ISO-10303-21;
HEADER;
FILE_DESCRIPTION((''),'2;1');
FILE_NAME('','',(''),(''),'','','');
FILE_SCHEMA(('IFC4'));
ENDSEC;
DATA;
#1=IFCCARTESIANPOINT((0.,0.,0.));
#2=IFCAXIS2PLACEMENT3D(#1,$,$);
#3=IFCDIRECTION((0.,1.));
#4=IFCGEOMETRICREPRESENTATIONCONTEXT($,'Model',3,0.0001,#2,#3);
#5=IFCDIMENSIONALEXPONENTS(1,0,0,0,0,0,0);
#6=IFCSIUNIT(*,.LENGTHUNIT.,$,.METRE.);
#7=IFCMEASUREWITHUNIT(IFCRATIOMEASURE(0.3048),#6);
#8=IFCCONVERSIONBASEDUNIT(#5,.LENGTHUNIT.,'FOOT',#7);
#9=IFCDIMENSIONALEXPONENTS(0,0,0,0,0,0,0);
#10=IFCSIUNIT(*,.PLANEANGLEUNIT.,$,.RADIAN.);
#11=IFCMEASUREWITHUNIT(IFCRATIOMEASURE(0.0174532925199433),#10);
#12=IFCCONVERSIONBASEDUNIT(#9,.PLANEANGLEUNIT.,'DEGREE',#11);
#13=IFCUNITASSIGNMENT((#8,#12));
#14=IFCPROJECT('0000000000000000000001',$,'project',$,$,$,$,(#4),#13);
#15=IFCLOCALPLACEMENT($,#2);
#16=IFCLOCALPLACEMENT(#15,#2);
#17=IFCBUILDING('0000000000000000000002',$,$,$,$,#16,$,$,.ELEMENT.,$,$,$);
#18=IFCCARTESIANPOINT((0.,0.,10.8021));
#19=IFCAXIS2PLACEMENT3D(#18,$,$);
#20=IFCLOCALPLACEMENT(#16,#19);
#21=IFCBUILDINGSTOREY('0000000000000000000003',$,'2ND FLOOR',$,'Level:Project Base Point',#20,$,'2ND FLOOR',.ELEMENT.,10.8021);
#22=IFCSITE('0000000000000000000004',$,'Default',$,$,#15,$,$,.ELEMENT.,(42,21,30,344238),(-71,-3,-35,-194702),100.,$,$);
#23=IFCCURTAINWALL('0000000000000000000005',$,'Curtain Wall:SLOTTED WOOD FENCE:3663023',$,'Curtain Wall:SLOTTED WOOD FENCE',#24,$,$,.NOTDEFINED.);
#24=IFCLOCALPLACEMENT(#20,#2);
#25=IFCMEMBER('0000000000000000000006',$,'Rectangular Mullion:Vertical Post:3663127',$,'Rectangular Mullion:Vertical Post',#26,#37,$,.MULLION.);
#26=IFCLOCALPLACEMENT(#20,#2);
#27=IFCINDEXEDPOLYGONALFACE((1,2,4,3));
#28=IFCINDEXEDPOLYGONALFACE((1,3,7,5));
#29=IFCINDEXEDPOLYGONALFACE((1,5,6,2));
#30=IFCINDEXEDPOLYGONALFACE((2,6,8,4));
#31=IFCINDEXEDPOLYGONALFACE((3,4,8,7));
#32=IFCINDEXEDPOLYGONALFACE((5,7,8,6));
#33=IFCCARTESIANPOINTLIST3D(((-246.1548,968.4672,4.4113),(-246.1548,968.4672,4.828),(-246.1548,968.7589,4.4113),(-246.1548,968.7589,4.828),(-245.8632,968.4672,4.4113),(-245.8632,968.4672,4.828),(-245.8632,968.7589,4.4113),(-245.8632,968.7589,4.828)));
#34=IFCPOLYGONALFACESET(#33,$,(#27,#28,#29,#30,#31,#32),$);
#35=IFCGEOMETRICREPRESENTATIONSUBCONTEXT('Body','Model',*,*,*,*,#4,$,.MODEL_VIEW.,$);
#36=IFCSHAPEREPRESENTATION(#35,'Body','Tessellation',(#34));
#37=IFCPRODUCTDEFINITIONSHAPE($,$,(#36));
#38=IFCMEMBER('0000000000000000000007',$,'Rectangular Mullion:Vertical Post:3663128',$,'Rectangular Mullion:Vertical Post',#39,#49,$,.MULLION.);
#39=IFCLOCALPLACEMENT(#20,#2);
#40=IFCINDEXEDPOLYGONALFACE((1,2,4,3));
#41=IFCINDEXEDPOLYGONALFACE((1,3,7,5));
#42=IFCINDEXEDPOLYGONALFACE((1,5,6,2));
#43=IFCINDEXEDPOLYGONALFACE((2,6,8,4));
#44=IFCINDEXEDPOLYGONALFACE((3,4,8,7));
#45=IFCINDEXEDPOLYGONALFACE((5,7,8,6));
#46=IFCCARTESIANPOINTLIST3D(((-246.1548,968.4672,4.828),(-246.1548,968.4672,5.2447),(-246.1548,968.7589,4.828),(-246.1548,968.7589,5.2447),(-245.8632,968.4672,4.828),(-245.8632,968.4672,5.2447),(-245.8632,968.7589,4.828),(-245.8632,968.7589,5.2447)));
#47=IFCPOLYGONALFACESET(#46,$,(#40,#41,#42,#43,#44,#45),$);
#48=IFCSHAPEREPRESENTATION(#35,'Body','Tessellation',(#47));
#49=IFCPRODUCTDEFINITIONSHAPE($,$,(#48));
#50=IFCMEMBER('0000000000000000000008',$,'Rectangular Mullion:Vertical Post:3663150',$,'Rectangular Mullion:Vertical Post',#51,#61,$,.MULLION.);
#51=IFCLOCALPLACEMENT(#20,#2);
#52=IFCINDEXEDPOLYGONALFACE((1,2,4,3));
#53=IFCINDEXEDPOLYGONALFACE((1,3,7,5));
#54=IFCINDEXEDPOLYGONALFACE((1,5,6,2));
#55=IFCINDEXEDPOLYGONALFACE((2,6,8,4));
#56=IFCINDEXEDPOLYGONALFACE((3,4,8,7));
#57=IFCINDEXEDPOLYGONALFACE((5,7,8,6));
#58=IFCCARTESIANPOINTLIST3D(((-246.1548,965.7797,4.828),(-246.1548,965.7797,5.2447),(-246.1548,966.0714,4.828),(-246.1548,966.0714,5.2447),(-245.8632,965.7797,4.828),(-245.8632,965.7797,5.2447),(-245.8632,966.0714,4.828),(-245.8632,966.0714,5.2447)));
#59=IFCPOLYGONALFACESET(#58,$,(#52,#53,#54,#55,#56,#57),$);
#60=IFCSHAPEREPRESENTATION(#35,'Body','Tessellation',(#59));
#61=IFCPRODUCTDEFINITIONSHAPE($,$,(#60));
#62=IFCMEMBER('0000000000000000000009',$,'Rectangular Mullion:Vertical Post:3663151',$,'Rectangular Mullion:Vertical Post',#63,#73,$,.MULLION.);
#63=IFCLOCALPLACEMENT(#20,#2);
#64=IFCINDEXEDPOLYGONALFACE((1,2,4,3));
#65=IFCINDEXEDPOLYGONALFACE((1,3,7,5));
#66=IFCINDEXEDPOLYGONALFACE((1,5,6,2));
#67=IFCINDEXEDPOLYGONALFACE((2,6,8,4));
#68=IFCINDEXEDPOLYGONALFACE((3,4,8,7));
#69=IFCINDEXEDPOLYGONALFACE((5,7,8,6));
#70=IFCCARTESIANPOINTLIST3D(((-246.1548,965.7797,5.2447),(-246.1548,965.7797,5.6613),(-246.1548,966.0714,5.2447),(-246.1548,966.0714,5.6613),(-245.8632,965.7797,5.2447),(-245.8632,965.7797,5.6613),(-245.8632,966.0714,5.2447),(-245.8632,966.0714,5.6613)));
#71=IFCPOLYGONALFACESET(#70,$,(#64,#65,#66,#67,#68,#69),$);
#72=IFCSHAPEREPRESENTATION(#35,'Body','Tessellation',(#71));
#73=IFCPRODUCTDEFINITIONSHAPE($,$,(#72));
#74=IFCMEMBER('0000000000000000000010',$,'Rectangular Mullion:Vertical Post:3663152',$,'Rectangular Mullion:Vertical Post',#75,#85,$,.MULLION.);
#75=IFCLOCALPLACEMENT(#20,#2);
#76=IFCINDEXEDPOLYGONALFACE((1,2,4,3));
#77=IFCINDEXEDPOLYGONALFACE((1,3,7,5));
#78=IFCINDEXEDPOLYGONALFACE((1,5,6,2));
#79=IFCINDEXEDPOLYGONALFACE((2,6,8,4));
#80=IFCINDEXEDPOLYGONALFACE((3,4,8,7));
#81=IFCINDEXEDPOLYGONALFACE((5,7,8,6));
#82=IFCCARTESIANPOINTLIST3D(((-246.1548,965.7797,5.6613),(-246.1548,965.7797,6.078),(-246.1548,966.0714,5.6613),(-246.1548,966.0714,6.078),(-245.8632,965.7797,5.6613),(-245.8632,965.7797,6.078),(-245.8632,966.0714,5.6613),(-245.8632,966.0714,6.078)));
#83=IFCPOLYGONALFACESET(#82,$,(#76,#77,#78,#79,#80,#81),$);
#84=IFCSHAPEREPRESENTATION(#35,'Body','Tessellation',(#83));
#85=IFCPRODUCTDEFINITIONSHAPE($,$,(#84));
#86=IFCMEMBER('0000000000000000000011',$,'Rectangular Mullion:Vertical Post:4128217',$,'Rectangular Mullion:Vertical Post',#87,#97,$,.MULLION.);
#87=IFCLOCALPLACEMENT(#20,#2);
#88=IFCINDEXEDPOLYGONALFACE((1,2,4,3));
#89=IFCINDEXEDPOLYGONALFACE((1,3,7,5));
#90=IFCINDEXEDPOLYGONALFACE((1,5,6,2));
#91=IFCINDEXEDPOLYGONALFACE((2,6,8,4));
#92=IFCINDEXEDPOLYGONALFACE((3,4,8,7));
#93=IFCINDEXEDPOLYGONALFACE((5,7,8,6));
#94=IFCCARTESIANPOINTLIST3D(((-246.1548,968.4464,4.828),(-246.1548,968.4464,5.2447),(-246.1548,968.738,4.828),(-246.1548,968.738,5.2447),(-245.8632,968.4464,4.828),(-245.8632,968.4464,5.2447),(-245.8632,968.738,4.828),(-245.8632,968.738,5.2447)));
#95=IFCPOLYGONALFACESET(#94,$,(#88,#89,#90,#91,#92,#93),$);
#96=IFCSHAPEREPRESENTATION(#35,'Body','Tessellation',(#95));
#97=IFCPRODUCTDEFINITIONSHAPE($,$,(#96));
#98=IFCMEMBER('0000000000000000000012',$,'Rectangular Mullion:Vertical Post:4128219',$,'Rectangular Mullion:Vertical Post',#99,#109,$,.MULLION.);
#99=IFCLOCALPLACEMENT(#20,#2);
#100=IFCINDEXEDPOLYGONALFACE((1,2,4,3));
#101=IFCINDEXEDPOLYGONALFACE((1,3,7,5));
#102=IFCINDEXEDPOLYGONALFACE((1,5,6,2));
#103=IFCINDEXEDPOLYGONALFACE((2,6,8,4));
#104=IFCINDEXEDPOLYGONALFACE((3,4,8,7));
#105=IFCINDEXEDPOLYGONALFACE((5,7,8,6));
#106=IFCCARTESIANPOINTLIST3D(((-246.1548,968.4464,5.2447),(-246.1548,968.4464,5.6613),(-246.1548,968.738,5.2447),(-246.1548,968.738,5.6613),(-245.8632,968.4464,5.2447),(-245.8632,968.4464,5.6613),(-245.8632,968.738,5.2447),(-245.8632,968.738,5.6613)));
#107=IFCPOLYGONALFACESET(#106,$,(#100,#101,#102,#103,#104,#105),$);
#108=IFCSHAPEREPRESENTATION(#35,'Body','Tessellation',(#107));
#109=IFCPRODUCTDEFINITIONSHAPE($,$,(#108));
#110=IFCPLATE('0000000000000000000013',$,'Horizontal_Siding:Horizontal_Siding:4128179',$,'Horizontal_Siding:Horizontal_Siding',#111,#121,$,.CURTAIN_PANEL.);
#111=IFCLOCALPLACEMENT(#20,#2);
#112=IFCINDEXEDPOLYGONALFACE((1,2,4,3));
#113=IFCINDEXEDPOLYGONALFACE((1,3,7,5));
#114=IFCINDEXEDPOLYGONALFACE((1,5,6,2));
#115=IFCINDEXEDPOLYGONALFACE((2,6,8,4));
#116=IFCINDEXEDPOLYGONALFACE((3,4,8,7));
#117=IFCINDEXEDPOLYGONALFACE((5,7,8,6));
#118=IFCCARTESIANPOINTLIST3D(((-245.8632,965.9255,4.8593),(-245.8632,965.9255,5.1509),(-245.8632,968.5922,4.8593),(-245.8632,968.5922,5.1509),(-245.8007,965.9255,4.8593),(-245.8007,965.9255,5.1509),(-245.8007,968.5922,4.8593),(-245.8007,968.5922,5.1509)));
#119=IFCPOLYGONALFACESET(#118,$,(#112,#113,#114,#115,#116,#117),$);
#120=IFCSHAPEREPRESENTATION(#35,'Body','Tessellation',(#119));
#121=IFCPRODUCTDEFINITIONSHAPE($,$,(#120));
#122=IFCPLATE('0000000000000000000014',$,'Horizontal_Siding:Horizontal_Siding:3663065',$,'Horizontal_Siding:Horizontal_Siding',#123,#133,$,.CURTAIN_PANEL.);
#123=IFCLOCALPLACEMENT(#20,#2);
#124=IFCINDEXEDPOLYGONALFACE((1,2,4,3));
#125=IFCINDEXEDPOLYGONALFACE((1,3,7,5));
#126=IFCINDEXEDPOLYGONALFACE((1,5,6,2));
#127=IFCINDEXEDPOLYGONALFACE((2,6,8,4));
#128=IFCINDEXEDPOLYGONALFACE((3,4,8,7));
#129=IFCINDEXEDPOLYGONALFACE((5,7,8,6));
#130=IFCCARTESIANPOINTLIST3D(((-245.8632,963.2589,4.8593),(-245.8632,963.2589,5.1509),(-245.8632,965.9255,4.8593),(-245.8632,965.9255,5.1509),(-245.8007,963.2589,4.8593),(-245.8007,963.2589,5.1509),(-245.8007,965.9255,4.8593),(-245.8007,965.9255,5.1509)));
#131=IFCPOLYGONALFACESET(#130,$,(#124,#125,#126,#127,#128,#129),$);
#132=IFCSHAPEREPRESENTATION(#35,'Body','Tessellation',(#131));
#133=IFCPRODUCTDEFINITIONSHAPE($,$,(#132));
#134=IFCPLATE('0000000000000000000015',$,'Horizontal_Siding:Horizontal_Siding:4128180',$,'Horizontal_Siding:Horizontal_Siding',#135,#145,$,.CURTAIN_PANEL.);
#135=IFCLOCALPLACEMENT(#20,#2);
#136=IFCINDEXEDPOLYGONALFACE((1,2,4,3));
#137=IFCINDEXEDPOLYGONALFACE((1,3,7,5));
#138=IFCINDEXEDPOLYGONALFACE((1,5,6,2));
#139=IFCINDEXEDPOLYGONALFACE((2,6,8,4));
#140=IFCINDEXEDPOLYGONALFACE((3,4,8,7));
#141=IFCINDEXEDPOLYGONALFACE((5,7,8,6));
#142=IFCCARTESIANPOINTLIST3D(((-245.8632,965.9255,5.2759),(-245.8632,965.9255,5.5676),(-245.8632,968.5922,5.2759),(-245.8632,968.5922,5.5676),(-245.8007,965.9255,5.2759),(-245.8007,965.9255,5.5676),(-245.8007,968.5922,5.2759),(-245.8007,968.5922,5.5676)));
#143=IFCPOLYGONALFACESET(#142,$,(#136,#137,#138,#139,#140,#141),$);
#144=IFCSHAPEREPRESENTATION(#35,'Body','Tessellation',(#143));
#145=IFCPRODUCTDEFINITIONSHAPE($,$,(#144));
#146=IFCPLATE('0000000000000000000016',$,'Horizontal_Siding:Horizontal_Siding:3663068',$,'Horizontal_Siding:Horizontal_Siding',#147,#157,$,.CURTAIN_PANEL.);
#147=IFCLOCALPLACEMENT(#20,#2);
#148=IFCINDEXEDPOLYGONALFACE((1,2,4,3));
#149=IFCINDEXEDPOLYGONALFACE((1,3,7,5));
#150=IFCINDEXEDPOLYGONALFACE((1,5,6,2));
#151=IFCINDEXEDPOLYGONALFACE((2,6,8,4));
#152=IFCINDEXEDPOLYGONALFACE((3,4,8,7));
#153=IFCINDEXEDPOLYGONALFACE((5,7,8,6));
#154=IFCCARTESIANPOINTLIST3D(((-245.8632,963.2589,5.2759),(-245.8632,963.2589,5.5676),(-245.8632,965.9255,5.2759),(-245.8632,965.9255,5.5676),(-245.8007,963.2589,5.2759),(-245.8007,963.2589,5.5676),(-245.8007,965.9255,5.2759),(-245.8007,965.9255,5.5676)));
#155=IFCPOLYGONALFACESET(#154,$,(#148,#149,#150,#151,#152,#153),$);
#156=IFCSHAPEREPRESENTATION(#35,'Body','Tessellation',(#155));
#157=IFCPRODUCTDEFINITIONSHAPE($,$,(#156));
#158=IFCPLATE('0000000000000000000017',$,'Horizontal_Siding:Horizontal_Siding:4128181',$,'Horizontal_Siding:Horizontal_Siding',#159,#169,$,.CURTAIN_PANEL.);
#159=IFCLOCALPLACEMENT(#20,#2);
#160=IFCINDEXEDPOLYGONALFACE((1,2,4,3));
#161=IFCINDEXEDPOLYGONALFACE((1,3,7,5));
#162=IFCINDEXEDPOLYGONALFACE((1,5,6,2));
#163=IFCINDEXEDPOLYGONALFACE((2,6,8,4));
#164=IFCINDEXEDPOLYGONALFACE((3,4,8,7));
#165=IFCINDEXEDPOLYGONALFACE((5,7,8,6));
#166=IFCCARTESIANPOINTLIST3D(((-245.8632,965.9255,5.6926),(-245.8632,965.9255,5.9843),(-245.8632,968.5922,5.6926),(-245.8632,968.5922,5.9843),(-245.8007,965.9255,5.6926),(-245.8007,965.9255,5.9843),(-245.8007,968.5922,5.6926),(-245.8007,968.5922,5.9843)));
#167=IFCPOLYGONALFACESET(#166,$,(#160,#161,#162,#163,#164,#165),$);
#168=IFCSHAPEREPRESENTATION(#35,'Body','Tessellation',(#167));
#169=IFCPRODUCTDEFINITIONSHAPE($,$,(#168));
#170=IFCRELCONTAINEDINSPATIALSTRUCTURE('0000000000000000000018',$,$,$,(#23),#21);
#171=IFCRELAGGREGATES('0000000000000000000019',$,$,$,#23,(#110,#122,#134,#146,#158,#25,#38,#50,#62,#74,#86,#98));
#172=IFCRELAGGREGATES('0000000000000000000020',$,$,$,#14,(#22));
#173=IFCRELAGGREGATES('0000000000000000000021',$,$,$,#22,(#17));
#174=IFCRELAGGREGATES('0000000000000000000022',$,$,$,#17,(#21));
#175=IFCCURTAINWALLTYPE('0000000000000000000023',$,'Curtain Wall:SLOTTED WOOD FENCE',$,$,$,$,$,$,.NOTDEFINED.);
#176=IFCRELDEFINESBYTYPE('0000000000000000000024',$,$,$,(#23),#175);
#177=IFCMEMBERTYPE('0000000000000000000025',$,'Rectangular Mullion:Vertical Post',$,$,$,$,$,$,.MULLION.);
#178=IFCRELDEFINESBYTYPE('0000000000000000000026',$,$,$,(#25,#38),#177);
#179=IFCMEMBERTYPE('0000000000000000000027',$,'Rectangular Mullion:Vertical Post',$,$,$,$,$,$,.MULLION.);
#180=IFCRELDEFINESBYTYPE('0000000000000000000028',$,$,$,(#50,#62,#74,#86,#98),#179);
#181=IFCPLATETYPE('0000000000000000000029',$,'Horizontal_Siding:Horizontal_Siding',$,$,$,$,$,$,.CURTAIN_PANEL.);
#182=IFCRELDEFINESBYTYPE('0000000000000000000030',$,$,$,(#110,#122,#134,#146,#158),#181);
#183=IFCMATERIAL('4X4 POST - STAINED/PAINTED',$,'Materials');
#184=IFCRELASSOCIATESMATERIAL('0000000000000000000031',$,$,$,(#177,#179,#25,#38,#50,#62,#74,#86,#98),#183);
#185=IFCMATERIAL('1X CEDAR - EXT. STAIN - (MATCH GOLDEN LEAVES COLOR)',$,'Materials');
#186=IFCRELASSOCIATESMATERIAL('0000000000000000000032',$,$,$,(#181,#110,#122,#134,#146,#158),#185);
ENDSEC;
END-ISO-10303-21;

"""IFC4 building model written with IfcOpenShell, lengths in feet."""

from ifc_helpers import new_model, entity, si_unit, converted_unit, direction, frame, origin, origin_2d_with_axis, place, context, subcontext, project, spatial, rectangle, extrude, source, transform, mapped, material, material_profile, profile_set, profile_usage, type_object, type_shapes, element, aggregate, save


model = new_model("IFC4")

# Units and contexts
model_context = context("Model", 3, precision=0.0001, world=origin(), true_north=direction((0.0, 1.0)))
body_context = subcontext(model_context, "Body", "Model", "MODEL_VIEW")
ifc_project = project(units=[converted_unit("LENGTHUNIT", "FOOT", entity("IfcRatioMeasure", 0.3048), si_unit("LENGTHUNIT", "METRE"), dimensions=[1, 0, 0, 0, 0, 0, 0]), converted_unit("PLANEANGLEUNIT", "DEGREE", entity("IfcRatioMeasure", 0.0174532925199433), si_unit("PLANEANGLEUNIT", "RADIAN"), dimensions=[0, 0, 0, 0, 0, 0, 0])], contexts=[model_context])

# Site, building, storey
site_placement = place(None, origin())
site = spatial("IfcSite", under=ifc_project, at=site_placement, Name="Default", CompositionType="ELEMENT", RefLatitude=(42, 21, 30, 344238), RefLongitude=(-71, -3, -35, -194702), RefElevation=100.0)
building_placement = place(site_placement, origin())
building = spatial("IfcBuilding", under=site, at=building_placement, CompositionType="ELEMENT")
storey_placement = place(building_placement, frame((0.0, 0.0, 10.8021)))
storey = spatial("IfcBuildingStorey", under=building, at=storey_placement, Name="2ND FLOOR", ObjectType="Level:Project Base Point", LongName="2ND FLOOR", CompositionType="ELEMENT", Elevation=10.8021)

# Curtain wall, members, plates
curtain_wall_type = type_object("IfcCurtainWallType", Name="Curtain Wall:SLOTTED WOOD FENCE", PredefinedType="NOTDEFINED")
curtain_wall_placement = place(storey_placement, frame((0.0, 0.0, -10.8021)))
curtain_wall = element("IfcCurtainWall", 1, at=curtain_wall_placement, inside=storey, type_object=curtain_wall_type, Name="Curtain Wall:SLOTTED WOOD FENCE:3663023", ObjectType="Curtain Wall:SLOTTED WOOD FENCE", PredefinedType="NOTDEFINED")
ifc_material_1 = material(Name="4X4 POST - STAINED/PAINTED", Category="Materials")
ifc_material_profile = material_profile(ifc_material_1, rectangle(XDim=0.2917, YDim=0.2917, at=origin_2d_with_axis()), Name="Vertical Post")
ifc_profile_set = profile_set([ifc_material_profile], Name="Vertical Post")
ifc_profile_usage_1 = profile_usage(ifc_profile_set)
member_type_1 = type_object("IfcMemberType", Name="Rectangular Mullion:Vertical Post", PredefinedType="MULLION", material=ifc_profile_set)
shared_shape_1 = source(origin(), body_context, "Body", "SweptSolid", [
    extrude(rectangle(XDim=0.2917, YDim=0.2917, at=origin_2d_with_axis()), frame((-0.1458, 0.2083, -0.4167), z_axis=(0.0, 0.0, 1.0), x_axis=(0.0, -1.0, 0.0)), (0.0, 0.0, 1.0), 0.4167),
])
type_shapes(member_type_1, [shared_shape_1])
member_1_placement = place(storey_placement, frame((-245.8007, 968.7589, 4.828), z_axis=(0.0, 0.0, 1.0), x_axis=(0.0, 1.0, 0.0)))
member_1 = element("IfcMember", 2, at=member_1_placement, type_object=member_type_1, material=ifc_profile_usage_1, Name="Rectangular Mullion:Vertical Post:3663127", ObjectType="Rectangular Mullion:Vertical Post", PredefinedType="MULLION", context=body_context, shape_type="MappedRepresentation", body=[
    mapped(shared_shape_1, transform((0.0, 0.0, 0.0), scale=1.0)),
])
ifc_profile_usage_2 = profile_usage(ifc_profile_set)
member_2_placement = place(storey_placement, frame((-245.8007, 968.7589, 5.2447), z_axis=(0.0, 0.0, 1.0), x_axis=(0.0, 1.0, 0.0)))
member_2 = element("IfcMember", 3, at=member_2_placement, type_object=member_type_1, material=ifc_profile_usage_2, Name="Rectangular Mullion:Vertical Post:3663128", ObjectType="Rectangular Mullion:Vertical Post", PredefinedType="MULLION", context=body_context, shape_type="MappedRepresentation", body=[
    mapped(shared_shape_1, transform((0.0, 0.0, 0.0), scale=1.0)),
])
ifc_profile_usage_3 = profile_usage(ifc_profile_set)
member_type_2 = type_object("IfcMemberType", Name="Rectangular Mullion:Vertical Post", PredefinedType="MULLION", material=ifc_profile_set)
shared_shape_2 = source(origin(), body_context, "Body", "SweptSolid", [
    extrude(rectangle(XDim=0.2917, YDim=0.2917, at=origin_2d_with_axis()), frame((0.0, 0.2083, -0.4167), z_axis=(0.0, 0.0, 1.0), x_axis=(0.0, -1.0, 0.0)), (0.0, 0.0, 1.0), 0.4167),
])
type_shapes(member_type_2, [shared_shape_2])
member_3_placement = place(storey_placement, frame((-245.8007, 965.9255, 4.828), z_axis=(0.0, 0.0, -1.0), x_axis=(0.0, -1.0, 0.0)))
member_3 = element("IfcMember", 4, at=member_3_placement, type_object=member_type_2, material=ifc_profile_usage_3, Name="Rectangular Mullion:Vertical Post:3663150", ObjectType="Rectangular Mullion:Vertical Post", PredefinedType="MULLION", context=body_context, shape_type="MappedRepresentation", body=[
    mapped(shared_shape_2, transform((0.0, 0.0, 0.0), scale=1.0)),
])
ifc_profile_usage_4 = profile_usage(ifc_profile_set)
member_4_placement = place(storey_placement, frame((-245.8007, 965.9255, 5.2447), z_axis=(0.0, 0.0, -1.0), x_axis=(0.0, -1.0, 0.0)))
member_4 = element("IfcMember", 5, at=member_4_placement, type_object=member_type_2, material=ifc_profile_usage_4, Name="Rectangular Mullion:Vertical Post:3663151", ObjectType="Rectangular Mullion:Vertical Post", PredefinedType="MULLION", context=body_context, shape_type="MappedRepresentation", body=[
    mapped(shared_shape_2, transform((0.0, 0.0, 0.0), scale=1.0)),
])
ifc_profile_usage_5 = profile_usage(ifc_profile_set)
member_5_placement = place(storey_placement, frame((-245.8007, 965.9255, 5.6613), z_axis=(0.0, 0.0, -1.0), x_axis=(0.0, -1.0, 0.0)))
member_5 = element("IfcMember", 6, at=member_5_placement, type_object=member_type_2, material=ifc_profile_usage_5, Name="Rectangular Mullion:Vertical Post:3663152", ObjectType="Rectangular Mullion:Vertical Post", PredefinedType="MULLION", context=body_context, shape_type="MappedRepresentation", body=[
    mapped(shared_shape_2, transform((0.0, 0.0, 0.0), scale=1.0)),
])
ifc_profile_usage_6 = profile_usage(ifc_profile_set)
member_6_placement = place(storey_placement, frame((-245.8007, 968.5922, 4.828), z_axis=(0.0, 0.0, -1.0), x_axis=(0.0, -1.0, 0.0)))
member_6 = element("IfcMember", 7, at=member_6_placement, type_object=member_type_2, material=ifc_profile_usage_6, Name="Rectangular Mullion:Vertical Post:4128217", ObjectType="Rectangular Mullion:Vertical Post", PredefinedType="MULLION", context=body_context, shape_type="MappedRepresentation", body=[
    mapped(shared_shape_2, transform((0.0, 0.0, 0.0), scale=1.0)),
])
ifc_profile_usage_7 = profile_usage(ifc_profile_set)
member_7_placement = place(storey_placement, frame((-245.8007, 968.5922, 5.2447), z_axis=(0.0, 0.0, -1.0), x_axis=(0.0, -1.0, 0.0)))
member_7 = element("IfcMember", 8, at=member_7_placement, type_object=member_type_2, material=ifc_profile_usage_7, Name="Rectangular Mullion:Vertical Post:4128219", ObjectType="Rectangular Mullion:Vertical Post", PredefinedType="MULLION", context=body_context, shape_type="MappedRepresentation", body=[
    mapped(shared_shape_2, transform((0.0, 0.0, 0.0), scale=1.0)),
])
ifc_material_2 = material(Name="1X CEDAR - EXT. STAIN - (MATCH GOLDEN LEAVES COLOR)", Category="Materials")
plate_type_1 = type_object("IfcPlateType", Name="Horizontal_Siding:Horizontal_Siding", PredefinedType="CURTAIN_PANEL", material=ifc_material_2)
shared_shape_3 = source(origin(), body_context, "Body", "SweptSolid", [
    extrude(rectangle(XDim=0.0625, YDim=2.6667, at=origin_2d_with_axis()), frame((1.3333, 0.0312, 0.0), z_axis=(0.0, 0.0, 1.0), x_axis=(0.0, 1.0, 0.0)), (0.0, 0.0, 1.0), 0.2917),
])
type_shapes(plate_type_1, [shared_shape_3])
plate_1_placement = place(curtain_wall_placement, frame((-245.8632, 968.5922, 15.6613), z_axis=(0.0, 0.0, 1.0), x_axis=(0.0, -1.0, 0.0)))
plate_1 = element("IfcPlate", 9, at=plate_1_placement, type_object=plate_type_1, material=ifc_material_2, Name="Horizontal_Siding:Horizontal_Siding:4128179", ObjectType="Horizontal_Siding:Horizontal_Siding", PredefinedType="CURTAIN_PANEL", context=body_context, shape_type="MappedRepresentation", body=[
    mapped(shared_shape_3, transform((0.0, 0.0, 0.0), scale=1.0)),
])
plate_2_placement = place(curtain_wall_placement, frame((-245.8632, 965.9255, 15.6613), z_axis=(0.0, 0.0, 1.0), x_axis=(0.0, -1.0, 0.0)))
plate_2 = element("IfcPlate", 10, at=plate_2_placement, type_object=plate_type_1, material=ifc_material_2, Name="Horizontal_Siding:Horizontal_Siding:3663065", ObjectType="Horizontal_Siding:Horizontal_Siding", PredefinedType="CURTAIN_PANEL", context=body_context, shape_type="MappedRepresentation", body=[
    mapped(shared_shape_3, transform((0.0, 0.0, 0.0), scale=1.0)),
])
plate_3_placement = place(curtain_wall_placement, frame((-245.8632, 968.5922, 16.078), z_axis=(0.0, 0.0, 1.0), x_axis=(0.0, -1.0, 0.0)))
plate_3 = element("IfcPlate", 11, at=plate_3_placement, type_object=plate_type_1, material=ifc_material_2, Name="Horizontal_Siding:Horizontal_Siding:4128180", ObjectType="Horizontal_Siding:Horizontal_Siding", PredefinedType="CURTAIN_PANEL", context=body_context, shape_type="MappedRepresentation", body=[
    mapped(shared_shape_3, transform((0.0, 0.0, 0.0), scale=1.0)),
])
plate_4_placement = place(curtain_wall_placement, frame((-245.8632, 965.9255, 16.078), z_axis=(0.0, 0.0, 1.0), x_axis=(0.0, -1.0, 0.0)))
plate_4 = element("IfcPlate", 12, at=plate_4_placement, type_object=plate_type_1, material=ifc_material_2, Name="Horizontal_Siding:Horizontal_Siding:3663068", ObjectType="Horizontal_Siding:Horizontal_Siding", PredefinedType="CURTAIN_PANEL", context=body_context, shape_type="MappedRepresentation", body=[
    mapped(shared_shape_3, transform((0.0, 0.0, 0.0), scale=1.0)),
])
plate_5_placement = place(curtain_wall_placement, frame((-245.8632, 968.5922, 16.4947), z_axis=(0.0, 0.0, 1.0), x_axis=(0.0, -1.0, 0.0)))
plate_5 = element("IfcPlate", 13, at=plate_5_placement, type_object=plate_type_1, material=ifc_material_2, Name="Horizontal_Siding:Horizontal_Siding:4128181", ObjectType="Horizontal_Siding:Horizontal_Siding", PredefinedType="CURTAIN_PANEL", context=body_context, shape_type="MappedRepresentation", body=[
    mapped(shared_shape_3, transform((0.0, 0.0, 0.0), scale=1.0)),
])
aggregate(curtain_wall, [plate_1, plate_2, plate_3, plate_4, plate_5, member_1, member_2, member_3, member_4, member_5, member_6, member_7])

save(model, "model.ifc")
